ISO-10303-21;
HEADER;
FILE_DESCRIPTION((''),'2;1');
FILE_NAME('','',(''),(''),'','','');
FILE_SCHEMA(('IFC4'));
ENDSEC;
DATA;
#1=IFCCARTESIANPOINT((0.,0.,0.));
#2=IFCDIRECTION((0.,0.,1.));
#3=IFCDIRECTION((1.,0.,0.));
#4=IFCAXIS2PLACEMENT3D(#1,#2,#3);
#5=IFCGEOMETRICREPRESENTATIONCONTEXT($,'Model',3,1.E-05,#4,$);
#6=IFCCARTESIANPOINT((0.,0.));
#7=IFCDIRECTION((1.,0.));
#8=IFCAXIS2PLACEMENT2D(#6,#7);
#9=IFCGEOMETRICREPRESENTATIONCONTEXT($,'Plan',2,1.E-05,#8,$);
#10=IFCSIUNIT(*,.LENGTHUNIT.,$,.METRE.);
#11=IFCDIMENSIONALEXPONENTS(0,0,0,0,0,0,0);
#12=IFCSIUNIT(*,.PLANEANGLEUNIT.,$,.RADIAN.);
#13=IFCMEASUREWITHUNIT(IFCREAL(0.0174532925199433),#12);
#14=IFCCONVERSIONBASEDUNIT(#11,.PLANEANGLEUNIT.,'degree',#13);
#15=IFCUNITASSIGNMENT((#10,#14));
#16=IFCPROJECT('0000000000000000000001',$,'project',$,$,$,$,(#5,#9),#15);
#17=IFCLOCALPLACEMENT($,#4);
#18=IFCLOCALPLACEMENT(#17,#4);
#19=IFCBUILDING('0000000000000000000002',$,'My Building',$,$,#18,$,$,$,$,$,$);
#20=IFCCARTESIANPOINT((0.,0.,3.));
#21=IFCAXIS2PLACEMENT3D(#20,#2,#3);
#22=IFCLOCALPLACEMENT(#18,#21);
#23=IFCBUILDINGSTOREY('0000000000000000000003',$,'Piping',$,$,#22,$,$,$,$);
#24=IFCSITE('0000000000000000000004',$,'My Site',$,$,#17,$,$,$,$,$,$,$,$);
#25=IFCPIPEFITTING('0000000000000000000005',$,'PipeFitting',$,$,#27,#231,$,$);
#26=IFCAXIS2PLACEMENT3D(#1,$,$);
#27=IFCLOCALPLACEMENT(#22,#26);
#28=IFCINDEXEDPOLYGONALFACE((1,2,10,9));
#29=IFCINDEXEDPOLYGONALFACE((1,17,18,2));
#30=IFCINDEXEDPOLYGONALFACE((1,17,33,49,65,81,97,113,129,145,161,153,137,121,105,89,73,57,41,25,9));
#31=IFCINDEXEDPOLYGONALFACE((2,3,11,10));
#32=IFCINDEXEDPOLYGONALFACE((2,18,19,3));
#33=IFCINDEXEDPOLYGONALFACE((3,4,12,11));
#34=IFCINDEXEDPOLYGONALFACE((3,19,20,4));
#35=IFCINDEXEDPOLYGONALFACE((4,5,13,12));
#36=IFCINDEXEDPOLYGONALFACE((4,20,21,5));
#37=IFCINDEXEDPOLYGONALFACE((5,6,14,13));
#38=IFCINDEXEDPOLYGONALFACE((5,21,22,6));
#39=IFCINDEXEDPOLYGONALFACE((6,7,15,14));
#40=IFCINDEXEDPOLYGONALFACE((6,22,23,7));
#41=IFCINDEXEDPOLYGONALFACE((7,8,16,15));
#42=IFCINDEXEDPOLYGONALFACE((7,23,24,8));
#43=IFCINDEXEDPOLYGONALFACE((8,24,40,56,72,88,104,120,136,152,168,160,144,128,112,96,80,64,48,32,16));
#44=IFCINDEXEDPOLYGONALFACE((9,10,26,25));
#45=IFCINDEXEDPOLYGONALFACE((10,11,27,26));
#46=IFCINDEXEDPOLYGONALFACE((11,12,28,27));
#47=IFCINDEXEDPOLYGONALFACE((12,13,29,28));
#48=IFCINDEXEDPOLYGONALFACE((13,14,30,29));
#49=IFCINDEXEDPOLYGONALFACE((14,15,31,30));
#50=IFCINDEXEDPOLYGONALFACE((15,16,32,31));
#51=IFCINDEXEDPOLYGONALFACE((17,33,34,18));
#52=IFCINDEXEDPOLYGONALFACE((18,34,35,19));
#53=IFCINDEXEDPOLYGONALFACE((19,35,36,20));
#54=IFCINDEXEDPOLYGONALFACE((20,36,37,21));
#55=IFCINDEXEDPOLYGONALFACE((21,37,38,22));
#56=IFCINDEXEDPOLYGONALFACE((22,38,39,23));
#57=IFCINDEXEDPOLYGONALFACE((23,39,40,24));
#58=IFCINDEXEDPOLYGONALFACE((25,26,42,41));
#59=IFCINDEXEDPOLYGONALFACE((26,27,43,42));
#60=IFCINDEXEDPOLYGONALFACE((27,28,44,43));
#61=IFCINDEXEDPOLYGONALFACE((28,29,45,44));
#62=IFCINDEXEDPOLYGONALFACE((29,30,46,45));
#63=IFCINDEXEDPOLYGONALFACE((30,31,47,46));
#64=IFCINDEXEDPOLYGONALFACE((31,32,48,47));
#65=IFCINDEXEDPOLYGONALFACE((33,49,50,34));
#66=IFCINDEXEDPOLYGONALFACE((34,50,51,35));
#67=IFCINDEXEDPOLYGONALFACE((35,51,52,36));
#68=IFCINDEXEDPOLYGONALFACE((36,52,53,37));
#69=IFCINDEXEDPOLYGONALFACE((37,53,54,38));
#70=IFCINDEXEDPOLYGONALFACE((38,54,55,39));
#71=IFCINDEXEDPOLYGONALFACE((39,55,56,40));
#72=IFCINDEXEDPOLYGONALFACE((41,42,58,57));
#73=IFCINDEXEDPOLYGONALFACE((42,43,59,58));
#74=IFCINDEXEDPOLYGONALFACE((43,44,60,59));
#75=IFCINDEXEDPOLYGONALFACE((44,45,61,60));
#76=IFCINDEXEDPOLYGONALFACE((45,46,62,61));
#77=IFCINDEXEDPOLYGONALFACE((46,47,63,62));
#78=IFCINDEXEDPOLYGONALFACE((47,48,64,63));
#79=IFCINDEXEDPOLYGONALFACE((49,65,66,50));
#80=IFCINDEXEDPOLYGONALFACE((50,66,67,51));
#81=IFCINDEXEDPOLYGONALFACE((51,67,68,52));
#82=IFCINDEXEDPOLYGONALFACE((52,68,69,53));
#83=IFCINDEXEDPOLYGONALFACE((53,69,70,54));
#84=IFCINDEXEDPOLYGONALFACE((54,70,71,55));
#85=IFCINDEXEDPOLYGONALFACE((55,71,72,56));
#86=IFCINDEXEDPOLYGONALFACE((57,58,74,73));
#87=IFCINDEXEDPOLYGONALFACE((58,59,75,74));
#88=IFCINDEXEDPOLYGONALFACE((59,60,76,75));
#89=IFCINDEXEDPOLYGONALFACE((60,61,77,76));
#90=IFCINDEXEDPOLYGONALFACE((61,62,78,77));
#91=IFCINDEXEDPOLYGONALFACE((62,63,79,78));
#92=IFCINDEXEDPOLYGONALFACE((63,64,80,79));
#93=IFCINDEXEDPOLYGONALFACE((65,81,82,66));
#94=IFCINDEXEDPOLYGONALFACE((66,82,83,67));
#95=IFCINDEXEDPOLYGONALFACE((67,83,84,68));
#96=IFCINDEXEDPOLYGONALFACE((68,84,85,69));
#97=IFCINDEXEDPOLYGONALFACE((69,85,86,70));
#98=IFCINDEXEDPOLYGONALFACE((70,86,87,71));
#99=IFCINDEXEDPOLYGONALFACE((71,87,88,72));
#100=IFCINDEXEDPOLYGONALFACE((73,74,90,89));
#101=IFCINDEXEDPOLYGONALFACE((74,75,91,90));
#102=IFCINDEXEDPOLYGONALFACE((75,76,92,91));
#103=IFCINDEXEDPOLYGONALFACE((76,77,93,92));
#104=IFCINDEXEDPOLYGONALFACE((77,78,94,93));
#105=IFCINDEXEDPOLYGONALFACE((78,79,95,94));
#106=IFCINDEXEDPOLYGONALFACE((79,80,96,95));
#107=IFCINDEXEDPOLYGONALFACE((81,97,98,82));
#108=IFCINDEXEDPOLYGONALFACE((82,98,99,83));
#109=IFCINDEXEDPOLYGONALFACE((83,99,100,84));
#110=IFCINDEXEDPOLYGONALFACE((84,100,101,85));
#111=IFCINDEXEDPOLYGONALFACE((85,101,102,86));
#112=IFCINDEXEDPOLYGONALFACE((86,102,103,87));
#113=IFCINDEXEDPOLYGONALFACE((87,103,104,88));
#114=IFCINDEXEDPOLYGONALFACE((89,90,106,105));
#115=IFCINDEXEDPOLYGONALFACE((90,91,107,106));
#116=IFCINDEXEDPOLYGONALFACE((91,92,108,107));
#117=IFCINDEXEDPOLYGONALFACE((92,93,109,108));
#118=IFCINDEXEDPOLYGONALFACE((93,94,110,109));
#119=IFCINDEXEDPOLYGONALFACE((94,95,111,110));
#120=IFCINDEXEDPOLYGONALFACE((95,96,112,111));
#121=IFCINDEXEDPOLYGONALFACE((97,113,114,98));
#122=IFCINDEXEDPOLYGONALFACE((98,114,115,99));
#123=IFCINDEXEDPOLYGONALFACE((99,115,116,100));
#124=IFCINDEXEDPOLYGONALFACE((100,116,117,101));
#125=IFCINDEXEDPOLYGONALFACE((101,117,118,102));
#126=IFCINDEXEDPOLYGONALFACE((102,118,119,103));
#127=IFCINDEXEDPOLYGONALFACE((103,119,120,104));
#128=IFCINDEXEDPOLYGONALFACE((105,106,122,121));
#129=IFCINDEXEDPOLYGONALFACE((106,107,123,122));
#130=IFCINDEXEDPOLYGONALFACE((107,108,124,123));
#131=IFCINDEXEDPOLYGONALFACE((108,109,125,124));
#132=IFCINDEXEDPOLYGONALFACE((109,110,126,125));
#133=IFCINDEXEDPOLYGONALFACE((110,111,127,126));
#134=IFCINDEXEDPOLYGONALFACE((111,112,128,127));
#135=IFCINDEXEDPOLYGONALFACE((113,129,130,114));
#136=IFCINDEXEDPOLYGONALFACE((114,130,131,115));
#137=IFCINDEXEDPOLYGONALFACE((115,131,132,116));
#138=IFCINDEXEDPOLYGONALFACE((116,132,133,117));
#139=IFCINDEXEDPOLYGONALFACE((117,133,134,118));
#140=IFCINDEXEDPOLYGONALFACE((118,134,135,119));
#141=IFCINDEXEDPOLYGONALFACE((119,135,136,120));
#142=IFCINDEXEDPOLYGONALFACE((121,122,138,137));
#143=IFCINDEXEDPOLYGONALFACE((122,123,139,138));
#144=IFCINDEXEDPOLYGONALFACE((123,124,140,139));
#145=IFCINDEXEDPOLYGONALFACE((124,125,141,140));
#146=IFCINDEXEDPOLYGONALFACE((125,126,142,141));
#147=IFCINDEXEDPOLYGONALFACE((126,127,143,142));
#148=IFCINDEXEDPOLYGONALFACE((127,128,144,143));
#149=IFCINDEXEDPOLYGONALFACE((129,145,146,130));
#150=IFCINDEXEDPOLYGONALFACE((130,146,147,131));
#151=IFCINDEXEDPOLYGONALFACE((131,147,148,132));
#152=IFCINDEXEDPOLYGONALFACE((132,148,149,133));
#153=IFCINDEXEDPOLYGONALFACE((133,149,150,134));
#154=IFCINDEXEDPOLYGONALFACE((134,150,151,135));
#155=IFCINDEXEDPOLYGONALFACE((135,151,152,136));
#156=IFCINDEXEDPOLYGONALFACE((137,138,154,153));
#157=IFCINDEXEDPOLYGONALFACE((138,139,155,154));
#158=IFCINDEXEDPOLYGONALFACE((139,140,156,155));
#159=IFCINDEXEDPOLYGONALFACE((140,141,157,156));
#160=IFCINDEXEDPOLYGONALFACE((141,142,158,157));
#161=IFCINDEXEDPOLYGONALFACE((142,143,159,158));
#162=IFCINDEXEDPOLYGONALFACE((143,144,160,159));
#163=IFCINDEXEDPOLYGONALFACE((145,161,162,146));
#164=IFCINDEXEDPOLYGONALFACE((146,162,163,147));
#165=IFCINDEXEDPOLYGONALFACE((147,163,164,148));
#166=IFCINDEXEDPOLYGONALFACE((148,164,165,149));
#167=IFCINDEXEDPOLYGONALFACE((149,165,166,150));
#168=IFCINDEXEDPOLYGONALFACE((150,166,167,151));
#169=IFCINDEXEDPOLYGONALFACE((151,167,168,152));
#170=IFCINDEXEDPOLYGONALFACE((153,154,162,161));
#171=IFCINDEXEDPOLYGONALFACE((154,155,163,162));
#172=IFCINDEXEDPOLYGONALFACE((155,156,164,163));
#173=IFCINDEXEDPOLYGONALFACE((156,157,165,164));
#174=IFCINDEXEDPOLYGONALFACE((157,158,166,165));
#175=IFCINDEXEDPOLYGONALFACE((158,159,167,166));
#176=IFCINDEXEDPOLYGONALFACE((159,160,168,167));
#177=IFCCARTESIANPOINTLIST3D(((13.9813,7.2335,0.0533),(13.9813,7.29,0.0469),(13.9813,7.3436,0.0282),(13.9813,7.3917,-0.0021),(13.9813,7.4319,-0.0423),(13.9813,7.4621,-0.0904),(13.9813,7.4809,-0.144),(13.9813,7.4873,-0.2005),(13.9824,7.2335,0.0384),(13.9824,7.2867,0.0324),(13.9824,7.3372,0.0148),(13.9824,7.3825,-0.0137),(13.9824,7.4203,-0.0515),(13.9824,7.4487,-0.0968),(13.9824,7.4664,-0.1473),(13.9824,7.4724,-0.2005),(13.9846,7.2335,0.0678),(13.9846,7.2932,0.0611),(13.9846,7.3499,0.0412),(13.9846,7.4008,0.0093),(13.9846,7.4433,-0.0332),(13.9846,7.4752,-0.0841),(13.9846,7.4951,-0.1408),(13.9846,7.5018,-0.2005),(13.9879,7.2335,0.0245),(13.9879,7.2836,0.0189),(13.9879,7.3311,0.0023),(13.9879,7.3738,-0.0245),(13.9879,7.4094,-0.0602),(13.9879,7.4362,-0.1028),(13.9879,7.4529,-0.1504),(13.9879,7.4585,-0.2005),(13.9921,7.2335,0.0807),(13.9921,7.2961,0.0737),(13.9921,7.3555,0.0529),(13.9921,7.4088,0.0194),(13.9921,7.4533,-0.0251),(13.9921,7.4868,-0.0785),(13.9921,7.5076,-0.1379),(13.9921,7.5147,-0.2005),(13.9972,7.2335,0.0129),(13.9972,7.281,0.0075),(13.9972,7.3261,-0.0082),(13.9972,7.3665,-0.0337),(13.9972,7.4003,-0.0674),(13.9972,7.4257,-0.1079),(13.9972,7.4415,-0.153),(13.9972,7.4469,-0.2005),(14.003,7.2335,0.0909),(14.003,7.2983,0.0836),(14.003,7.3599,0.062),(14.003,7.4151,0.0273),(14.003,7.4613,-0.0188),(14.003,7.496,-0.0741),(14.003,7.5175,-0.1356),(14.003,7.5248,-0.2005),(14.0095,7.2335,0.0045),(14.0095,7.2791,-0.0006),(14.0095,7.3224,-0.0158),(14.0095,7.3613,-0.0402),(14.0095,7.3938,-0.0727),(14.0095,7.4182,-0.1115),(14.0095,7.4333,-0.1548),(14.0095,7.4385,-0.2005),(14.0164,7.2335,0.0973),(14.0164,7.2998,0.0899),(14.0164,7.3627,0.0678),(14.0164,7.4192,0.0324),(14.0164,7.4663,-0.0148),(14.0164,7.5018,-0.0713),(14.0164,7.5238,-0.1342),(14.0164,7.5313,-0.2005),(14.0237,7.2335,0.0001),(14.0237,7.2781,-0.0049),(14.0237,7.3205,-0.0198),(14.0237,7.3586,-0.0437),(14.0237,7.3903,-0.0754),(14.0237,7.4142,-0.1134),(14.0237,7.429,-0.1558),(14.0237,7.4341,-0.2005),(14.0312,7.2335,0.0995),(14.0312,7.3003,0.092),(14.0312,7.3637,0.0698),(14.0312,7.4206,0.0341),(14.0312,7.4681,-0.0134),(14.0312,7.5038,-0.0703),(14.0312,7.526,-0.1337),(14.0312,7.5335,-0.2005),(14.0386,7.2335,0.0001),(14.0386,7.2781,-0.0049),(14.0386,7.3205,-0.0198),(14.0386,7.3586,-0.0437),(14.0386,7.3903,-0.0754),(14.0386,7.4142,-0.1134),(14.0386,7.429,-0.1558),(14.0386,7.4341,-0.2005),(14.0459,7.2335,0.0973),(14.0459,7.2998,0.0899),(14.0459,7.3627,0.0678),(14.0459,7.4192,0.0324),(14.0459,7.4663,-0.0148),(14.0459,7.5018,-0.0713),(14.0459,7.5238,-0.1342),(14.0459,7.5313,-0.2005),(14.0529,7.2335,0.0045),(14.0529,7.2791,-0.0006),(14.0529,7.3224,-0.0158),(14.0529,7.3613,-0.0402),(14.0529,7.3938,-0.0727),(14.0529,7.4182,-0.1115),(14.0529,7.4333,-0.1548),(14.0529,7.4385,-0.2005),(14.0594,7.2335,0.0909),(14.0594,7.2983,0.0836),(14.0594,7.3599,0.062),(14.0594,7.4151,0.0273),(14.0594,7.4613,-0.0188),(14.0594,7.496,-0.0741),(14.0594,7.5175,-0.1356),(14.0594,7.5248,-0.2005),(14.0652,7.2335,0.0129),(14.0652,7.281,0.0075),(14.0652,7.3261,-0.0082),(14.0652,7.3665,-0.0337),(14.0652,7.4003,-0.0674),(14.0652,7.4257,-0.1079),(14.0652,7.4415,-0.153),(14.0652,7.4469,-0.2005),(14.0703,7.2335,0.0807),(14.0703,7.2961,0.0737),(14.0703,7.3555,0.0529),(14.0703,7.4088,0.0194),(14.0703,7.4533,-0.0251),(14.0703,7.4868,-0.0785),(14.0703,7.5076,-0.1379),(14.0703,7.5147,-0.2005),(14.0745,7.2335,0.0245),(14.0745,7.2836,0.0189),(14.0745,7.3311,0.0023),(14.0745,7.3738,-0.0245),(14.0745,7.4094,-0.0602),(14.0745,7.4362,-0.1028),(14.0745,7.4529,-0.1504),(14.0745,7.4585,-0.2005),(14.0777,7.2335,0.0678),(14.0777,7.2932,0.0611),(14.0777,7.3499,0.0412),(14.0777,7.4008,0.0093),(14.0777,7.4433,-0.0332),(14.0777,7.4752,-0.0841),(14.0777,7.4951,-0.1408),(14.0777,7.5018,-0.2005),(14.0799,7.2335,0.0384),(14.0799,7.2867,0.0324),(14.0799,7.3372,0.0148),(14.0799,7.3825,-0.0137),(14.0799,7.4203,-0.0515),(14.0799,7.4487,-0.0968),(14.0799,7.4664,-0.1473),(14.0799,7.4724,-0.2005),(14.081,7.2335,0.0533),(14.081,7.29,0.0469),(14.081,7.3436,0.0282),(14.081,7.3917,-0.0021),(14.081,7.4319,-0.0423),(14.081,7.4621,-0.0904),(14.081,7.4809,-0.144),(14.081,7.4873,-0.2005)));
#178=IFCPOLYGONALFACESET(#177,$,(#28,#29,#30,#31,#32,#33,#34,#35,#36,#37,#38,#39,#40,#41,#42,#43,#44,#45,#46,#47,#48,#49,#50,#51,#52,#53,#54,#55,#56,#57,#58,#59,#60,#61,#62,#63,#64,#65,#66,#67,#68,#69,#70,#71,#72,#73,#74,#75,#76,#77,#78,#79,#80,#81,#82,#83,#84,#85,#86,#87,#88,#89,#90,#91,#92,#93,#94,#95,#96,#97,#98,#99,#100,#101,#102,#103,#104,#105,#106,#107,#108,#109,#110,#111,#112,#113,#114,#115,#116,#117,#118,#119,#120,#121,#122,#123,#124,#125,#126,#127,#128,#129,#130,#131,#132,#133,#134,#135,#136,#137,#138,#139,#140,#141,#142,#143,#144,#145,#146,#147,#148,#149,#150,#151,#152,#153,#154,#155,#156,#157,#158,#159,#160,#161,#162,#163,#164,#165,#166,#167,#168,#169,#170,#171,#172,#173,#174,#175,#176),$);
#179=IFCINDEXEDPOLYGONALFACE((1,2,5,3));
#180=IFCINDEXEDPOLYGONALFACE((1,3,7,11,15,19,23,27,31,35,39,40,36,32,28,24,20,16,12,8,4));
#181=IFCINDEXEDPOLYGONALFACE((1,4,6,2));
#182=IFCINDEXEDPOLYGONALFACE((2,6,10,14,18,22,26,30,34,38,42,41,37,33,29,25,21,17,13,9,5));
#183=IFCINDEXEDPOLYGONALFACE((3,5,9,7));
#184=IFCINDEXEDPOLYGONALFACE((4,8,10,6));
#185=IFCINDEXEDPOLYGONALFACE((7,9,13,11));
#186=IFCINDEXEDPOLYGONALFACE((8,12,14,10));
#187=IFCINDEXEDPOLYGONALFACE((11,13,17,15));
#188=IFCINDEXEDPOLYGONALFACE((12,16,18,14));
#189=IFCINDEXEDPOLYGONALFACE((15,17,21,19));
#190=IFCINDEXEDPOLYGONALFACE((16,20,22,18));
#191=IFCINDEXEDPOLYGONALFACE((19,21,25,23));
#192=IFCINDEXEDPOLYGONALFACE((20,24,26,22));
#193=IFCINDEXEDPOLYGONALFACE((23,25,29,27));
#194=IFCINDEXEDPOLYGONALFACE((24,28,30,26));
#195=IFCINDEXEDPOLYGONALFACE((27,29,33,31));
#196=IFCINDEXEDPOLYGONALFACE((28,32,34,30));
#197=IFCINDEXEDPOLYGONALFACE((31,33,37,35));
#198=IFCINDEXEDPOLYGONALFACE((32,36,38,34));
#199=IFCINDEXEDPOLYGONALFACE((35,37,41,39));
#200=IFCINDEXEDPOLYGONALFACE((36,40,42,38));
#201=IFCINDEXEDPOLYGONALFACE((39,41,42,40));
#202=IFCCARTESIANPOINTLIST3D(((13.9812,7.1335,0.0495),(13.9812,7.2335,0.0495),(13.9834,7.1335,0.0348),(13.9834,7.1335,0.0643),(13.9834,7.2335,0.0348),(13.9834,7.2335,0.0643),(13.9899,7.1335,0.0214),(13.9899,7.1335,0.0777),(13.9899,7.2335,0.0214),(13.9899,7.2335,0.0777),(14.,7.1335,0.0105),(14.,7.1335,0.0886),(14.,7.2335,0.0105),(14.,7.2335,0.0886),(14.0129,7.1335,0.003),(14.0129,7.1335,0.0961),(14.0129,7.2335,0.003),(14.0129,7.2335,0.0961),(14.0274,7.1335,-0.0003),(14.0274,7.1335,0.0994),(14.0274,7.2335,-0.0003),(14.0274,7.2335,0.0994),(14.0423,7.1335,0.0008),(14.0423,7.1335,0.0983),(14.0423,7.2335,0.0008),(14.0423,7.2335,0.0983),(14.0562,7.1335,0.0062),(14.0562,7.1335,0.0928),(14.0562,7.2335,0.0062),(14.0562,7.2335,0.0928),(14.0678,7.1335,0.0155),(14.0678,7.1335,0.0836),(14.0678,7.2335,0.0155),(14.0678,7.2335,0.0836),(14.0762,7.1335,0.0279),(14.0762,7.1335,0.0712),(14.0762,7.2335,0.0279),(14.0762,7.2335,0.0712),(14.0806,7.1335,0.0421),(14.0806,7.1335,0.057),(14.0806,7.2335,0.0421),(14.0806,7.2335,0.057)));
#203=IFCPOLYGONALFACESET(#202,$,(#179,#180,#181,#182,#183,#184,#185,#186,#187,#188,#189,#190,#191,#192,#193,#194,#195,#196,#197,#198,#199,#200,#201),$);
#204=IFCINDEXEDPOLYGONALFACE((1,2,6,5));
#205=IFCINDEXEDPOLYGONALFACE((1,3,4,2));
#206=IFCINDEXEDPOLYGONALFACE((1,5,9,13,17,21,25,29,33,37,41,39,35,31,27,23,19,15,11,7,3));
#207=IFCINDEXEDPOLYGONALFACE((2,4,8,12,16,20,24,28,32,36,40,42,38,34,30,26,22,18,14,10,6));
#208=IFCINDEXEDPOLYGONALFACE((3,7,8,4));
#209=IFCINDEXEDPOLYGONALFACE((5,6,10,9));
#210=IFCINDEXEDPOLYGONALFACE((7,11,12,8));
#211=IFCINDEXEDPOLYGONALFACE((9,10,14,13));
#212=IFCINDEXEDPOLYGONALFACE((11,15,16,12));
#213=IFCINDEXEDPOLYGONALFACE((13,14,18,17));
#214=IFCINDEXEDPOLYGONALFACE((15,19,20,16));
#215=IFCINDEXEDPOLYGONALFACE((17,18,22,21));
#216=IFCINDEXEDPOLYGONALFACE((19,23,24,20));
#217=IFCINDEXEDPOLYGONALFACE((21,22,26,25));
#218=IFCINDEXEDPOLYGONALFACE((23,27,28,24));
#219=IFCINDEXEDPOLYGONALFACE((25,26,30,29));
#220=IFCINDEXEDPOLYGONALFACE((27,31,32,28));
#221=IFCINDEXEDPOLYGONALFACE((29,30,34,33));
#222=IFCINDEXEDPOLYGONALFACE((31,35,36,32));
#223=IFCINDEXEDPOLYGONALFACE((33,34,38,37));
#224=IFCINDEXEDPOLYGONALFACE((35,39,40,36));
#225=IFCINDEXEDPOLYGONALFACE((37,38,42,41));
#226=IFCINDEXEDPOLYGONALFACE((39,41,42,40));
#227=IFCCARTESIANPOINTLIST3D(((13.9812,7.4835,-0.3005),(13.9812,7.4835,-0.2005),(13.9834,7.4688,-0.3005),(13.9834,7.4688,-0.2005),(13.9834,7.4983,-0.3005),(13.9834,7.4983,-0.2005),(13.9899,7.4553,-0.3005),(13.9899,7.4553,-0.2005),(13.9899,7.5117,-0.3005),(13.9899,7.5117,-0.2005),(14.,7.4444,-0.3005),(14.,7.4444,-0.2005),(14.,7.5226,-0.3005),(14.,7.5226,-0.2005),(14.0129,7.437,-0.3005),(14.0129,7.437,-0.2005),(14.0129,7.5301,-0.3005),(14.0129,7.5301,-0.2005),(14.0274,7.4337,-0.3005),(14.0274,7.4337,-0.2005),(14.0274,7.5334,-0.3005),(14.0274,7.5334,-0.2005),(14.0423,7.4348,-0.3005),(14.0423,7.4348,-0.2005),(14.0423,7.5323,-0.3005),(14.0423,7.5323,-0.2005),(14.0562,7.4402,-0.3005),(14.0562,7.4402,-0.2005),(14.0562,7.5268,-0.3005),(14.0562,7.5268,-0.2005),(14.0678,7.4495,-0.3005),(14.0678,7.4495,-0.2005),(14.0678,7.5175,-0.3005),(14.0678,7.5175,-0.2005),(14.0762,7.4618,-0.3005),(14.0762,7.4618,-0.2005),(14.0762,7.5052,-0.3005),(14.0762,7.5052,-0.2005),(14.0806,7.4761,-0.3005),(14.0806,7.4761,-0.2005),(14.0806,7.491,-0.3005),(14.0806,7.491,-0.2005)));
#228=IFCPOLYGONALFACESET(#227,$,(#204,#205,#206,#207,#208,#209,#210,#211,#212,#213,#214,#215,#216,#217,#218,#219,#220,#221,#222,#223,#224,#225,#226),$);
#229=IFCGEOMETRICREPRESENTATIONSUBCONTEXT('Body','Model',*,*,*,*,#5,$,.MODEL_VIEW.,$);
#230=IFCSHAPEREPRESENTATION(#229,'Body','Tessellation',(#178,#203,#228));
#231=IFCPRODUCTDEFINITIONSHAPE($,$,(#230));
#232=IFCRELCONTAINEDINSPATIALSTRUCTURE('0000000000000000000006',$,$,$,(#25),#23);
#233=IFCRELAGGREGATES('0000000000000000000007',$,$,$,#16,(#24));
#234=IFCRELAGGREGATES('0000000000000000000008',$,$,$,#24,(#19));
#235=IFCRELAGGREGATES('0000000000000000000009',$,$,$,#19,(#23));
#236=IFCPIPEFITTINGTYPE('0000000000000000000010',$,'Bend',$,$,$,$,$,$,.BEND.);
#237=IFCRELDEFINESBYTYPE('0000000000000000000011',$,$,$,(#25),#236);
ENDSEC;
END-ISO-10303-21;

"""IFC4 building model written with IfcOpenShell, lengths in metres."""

from ifc_helpers import new_model, entity, si_unit, converted_unit, frame, origin_with_axes, origin_2d_with_axis, place, context, subcontext, project, spatial, circle, extrude, source, transform, mapped, type_object, type_shapes, element, save


model = new_model("IFC4")

# Units and contexts
model_context = context("Model", 3, precision=1e-05, world=origin_with_axes())
plan_context = context("Plan", 2, precision=1e-05, world=origin_2d_with_axis())
body_context = subcontext(model_context, "Body", "Model", "MODEL_VIEW")
ifc_project = project(units=[si_unit("LENGTHUNIT", "METRE"), converted_unit("PLANEANGLEUNIT", "degree", entity("IfcReal", 0.0174532925199433), si_unit("PLANEANGLEUNIT", "RADIAN"), dimensions=[0, 0, 0, 0, 0, 0, 0])], contexts=[model_context, plan_context])

# Site, building, storey
site_placement = place(None, origin_with_axes())
site = spatial("IfcSite", under=ifc_project, at=site_placement, Name="My Site")
building_placement = place(site_placement, origin_with_axes())
building = spatial("IfcBuilding", under=site, at=building_placement, Name="My Building")
storey_placement = place(building_placement, frame((0.0, 0.0, 3.0), z_axis=(0.0, 0.0, 1.0), x_axis=(1.0, 0.0, 0.0)))
storey = spatial("IfcBuildingStorey", under=building, at=storey_placement, Name="Piping")

# Pipe fitting
pipe_fitting_type = type_object("IfcPipeFittingType", Name="Bend", PredefinedType="BEND")
shared_shape = source(origin_with_axes(), body_context, "Body", "SolidModel", [
    entity("IfcSweptDiskSolid", entity("IfcIndexedPolyCurve", entity("IfcCartesianPointList3D", [[0.0, 0.0, 0.1], [0.0, -0.0732, 0.2768], [0.0, -0.25, 0.35]]), [entity("IfcArcIndex", [1, 2, 3])]), 0.05),
    extrude(circle(Radius=0.05), origin_with_axes(), (0.0, 0.0, 1.0), 0.1),
    extrude(circle(Radius=0.05), frame((0.0, -0.25, 0.35), z_axis=(0.0, -1.0, 0.0), x_axis=(1.0, 0.0, 0.0)), (0.0, 0.0, 1.0), 0.1),
])
type_shapes(pipe_fitting_type, [shared_shape])
for number, where, z_axis, x_axis, name in (
    (1, (14.0312, 7.1335, 0.0495), (0.0, 1.0, 0.0), (-1.0, 0.0, 0.0), "PipeFitting"),
):
    element("IfcPipeFitting", number, at=place(storey_placement, frame(where, z_axis=z_axis, x_axis=x_axis)), inside=storey, type_object=pipe_fitting_type, Name=name, context=body_context, shape_type="MappedRepresentation", body=[
        mapped(shared_shape, transform((0.0, 0.0, 0.0), x_axis=(1.0, 0.0, 0.0), y_axis=(0.0, 1.0, 0.0), z_axis=(0.0, 0.0, 1.0), scale=1.0)),
    ])

save(model, "model.ifc")
